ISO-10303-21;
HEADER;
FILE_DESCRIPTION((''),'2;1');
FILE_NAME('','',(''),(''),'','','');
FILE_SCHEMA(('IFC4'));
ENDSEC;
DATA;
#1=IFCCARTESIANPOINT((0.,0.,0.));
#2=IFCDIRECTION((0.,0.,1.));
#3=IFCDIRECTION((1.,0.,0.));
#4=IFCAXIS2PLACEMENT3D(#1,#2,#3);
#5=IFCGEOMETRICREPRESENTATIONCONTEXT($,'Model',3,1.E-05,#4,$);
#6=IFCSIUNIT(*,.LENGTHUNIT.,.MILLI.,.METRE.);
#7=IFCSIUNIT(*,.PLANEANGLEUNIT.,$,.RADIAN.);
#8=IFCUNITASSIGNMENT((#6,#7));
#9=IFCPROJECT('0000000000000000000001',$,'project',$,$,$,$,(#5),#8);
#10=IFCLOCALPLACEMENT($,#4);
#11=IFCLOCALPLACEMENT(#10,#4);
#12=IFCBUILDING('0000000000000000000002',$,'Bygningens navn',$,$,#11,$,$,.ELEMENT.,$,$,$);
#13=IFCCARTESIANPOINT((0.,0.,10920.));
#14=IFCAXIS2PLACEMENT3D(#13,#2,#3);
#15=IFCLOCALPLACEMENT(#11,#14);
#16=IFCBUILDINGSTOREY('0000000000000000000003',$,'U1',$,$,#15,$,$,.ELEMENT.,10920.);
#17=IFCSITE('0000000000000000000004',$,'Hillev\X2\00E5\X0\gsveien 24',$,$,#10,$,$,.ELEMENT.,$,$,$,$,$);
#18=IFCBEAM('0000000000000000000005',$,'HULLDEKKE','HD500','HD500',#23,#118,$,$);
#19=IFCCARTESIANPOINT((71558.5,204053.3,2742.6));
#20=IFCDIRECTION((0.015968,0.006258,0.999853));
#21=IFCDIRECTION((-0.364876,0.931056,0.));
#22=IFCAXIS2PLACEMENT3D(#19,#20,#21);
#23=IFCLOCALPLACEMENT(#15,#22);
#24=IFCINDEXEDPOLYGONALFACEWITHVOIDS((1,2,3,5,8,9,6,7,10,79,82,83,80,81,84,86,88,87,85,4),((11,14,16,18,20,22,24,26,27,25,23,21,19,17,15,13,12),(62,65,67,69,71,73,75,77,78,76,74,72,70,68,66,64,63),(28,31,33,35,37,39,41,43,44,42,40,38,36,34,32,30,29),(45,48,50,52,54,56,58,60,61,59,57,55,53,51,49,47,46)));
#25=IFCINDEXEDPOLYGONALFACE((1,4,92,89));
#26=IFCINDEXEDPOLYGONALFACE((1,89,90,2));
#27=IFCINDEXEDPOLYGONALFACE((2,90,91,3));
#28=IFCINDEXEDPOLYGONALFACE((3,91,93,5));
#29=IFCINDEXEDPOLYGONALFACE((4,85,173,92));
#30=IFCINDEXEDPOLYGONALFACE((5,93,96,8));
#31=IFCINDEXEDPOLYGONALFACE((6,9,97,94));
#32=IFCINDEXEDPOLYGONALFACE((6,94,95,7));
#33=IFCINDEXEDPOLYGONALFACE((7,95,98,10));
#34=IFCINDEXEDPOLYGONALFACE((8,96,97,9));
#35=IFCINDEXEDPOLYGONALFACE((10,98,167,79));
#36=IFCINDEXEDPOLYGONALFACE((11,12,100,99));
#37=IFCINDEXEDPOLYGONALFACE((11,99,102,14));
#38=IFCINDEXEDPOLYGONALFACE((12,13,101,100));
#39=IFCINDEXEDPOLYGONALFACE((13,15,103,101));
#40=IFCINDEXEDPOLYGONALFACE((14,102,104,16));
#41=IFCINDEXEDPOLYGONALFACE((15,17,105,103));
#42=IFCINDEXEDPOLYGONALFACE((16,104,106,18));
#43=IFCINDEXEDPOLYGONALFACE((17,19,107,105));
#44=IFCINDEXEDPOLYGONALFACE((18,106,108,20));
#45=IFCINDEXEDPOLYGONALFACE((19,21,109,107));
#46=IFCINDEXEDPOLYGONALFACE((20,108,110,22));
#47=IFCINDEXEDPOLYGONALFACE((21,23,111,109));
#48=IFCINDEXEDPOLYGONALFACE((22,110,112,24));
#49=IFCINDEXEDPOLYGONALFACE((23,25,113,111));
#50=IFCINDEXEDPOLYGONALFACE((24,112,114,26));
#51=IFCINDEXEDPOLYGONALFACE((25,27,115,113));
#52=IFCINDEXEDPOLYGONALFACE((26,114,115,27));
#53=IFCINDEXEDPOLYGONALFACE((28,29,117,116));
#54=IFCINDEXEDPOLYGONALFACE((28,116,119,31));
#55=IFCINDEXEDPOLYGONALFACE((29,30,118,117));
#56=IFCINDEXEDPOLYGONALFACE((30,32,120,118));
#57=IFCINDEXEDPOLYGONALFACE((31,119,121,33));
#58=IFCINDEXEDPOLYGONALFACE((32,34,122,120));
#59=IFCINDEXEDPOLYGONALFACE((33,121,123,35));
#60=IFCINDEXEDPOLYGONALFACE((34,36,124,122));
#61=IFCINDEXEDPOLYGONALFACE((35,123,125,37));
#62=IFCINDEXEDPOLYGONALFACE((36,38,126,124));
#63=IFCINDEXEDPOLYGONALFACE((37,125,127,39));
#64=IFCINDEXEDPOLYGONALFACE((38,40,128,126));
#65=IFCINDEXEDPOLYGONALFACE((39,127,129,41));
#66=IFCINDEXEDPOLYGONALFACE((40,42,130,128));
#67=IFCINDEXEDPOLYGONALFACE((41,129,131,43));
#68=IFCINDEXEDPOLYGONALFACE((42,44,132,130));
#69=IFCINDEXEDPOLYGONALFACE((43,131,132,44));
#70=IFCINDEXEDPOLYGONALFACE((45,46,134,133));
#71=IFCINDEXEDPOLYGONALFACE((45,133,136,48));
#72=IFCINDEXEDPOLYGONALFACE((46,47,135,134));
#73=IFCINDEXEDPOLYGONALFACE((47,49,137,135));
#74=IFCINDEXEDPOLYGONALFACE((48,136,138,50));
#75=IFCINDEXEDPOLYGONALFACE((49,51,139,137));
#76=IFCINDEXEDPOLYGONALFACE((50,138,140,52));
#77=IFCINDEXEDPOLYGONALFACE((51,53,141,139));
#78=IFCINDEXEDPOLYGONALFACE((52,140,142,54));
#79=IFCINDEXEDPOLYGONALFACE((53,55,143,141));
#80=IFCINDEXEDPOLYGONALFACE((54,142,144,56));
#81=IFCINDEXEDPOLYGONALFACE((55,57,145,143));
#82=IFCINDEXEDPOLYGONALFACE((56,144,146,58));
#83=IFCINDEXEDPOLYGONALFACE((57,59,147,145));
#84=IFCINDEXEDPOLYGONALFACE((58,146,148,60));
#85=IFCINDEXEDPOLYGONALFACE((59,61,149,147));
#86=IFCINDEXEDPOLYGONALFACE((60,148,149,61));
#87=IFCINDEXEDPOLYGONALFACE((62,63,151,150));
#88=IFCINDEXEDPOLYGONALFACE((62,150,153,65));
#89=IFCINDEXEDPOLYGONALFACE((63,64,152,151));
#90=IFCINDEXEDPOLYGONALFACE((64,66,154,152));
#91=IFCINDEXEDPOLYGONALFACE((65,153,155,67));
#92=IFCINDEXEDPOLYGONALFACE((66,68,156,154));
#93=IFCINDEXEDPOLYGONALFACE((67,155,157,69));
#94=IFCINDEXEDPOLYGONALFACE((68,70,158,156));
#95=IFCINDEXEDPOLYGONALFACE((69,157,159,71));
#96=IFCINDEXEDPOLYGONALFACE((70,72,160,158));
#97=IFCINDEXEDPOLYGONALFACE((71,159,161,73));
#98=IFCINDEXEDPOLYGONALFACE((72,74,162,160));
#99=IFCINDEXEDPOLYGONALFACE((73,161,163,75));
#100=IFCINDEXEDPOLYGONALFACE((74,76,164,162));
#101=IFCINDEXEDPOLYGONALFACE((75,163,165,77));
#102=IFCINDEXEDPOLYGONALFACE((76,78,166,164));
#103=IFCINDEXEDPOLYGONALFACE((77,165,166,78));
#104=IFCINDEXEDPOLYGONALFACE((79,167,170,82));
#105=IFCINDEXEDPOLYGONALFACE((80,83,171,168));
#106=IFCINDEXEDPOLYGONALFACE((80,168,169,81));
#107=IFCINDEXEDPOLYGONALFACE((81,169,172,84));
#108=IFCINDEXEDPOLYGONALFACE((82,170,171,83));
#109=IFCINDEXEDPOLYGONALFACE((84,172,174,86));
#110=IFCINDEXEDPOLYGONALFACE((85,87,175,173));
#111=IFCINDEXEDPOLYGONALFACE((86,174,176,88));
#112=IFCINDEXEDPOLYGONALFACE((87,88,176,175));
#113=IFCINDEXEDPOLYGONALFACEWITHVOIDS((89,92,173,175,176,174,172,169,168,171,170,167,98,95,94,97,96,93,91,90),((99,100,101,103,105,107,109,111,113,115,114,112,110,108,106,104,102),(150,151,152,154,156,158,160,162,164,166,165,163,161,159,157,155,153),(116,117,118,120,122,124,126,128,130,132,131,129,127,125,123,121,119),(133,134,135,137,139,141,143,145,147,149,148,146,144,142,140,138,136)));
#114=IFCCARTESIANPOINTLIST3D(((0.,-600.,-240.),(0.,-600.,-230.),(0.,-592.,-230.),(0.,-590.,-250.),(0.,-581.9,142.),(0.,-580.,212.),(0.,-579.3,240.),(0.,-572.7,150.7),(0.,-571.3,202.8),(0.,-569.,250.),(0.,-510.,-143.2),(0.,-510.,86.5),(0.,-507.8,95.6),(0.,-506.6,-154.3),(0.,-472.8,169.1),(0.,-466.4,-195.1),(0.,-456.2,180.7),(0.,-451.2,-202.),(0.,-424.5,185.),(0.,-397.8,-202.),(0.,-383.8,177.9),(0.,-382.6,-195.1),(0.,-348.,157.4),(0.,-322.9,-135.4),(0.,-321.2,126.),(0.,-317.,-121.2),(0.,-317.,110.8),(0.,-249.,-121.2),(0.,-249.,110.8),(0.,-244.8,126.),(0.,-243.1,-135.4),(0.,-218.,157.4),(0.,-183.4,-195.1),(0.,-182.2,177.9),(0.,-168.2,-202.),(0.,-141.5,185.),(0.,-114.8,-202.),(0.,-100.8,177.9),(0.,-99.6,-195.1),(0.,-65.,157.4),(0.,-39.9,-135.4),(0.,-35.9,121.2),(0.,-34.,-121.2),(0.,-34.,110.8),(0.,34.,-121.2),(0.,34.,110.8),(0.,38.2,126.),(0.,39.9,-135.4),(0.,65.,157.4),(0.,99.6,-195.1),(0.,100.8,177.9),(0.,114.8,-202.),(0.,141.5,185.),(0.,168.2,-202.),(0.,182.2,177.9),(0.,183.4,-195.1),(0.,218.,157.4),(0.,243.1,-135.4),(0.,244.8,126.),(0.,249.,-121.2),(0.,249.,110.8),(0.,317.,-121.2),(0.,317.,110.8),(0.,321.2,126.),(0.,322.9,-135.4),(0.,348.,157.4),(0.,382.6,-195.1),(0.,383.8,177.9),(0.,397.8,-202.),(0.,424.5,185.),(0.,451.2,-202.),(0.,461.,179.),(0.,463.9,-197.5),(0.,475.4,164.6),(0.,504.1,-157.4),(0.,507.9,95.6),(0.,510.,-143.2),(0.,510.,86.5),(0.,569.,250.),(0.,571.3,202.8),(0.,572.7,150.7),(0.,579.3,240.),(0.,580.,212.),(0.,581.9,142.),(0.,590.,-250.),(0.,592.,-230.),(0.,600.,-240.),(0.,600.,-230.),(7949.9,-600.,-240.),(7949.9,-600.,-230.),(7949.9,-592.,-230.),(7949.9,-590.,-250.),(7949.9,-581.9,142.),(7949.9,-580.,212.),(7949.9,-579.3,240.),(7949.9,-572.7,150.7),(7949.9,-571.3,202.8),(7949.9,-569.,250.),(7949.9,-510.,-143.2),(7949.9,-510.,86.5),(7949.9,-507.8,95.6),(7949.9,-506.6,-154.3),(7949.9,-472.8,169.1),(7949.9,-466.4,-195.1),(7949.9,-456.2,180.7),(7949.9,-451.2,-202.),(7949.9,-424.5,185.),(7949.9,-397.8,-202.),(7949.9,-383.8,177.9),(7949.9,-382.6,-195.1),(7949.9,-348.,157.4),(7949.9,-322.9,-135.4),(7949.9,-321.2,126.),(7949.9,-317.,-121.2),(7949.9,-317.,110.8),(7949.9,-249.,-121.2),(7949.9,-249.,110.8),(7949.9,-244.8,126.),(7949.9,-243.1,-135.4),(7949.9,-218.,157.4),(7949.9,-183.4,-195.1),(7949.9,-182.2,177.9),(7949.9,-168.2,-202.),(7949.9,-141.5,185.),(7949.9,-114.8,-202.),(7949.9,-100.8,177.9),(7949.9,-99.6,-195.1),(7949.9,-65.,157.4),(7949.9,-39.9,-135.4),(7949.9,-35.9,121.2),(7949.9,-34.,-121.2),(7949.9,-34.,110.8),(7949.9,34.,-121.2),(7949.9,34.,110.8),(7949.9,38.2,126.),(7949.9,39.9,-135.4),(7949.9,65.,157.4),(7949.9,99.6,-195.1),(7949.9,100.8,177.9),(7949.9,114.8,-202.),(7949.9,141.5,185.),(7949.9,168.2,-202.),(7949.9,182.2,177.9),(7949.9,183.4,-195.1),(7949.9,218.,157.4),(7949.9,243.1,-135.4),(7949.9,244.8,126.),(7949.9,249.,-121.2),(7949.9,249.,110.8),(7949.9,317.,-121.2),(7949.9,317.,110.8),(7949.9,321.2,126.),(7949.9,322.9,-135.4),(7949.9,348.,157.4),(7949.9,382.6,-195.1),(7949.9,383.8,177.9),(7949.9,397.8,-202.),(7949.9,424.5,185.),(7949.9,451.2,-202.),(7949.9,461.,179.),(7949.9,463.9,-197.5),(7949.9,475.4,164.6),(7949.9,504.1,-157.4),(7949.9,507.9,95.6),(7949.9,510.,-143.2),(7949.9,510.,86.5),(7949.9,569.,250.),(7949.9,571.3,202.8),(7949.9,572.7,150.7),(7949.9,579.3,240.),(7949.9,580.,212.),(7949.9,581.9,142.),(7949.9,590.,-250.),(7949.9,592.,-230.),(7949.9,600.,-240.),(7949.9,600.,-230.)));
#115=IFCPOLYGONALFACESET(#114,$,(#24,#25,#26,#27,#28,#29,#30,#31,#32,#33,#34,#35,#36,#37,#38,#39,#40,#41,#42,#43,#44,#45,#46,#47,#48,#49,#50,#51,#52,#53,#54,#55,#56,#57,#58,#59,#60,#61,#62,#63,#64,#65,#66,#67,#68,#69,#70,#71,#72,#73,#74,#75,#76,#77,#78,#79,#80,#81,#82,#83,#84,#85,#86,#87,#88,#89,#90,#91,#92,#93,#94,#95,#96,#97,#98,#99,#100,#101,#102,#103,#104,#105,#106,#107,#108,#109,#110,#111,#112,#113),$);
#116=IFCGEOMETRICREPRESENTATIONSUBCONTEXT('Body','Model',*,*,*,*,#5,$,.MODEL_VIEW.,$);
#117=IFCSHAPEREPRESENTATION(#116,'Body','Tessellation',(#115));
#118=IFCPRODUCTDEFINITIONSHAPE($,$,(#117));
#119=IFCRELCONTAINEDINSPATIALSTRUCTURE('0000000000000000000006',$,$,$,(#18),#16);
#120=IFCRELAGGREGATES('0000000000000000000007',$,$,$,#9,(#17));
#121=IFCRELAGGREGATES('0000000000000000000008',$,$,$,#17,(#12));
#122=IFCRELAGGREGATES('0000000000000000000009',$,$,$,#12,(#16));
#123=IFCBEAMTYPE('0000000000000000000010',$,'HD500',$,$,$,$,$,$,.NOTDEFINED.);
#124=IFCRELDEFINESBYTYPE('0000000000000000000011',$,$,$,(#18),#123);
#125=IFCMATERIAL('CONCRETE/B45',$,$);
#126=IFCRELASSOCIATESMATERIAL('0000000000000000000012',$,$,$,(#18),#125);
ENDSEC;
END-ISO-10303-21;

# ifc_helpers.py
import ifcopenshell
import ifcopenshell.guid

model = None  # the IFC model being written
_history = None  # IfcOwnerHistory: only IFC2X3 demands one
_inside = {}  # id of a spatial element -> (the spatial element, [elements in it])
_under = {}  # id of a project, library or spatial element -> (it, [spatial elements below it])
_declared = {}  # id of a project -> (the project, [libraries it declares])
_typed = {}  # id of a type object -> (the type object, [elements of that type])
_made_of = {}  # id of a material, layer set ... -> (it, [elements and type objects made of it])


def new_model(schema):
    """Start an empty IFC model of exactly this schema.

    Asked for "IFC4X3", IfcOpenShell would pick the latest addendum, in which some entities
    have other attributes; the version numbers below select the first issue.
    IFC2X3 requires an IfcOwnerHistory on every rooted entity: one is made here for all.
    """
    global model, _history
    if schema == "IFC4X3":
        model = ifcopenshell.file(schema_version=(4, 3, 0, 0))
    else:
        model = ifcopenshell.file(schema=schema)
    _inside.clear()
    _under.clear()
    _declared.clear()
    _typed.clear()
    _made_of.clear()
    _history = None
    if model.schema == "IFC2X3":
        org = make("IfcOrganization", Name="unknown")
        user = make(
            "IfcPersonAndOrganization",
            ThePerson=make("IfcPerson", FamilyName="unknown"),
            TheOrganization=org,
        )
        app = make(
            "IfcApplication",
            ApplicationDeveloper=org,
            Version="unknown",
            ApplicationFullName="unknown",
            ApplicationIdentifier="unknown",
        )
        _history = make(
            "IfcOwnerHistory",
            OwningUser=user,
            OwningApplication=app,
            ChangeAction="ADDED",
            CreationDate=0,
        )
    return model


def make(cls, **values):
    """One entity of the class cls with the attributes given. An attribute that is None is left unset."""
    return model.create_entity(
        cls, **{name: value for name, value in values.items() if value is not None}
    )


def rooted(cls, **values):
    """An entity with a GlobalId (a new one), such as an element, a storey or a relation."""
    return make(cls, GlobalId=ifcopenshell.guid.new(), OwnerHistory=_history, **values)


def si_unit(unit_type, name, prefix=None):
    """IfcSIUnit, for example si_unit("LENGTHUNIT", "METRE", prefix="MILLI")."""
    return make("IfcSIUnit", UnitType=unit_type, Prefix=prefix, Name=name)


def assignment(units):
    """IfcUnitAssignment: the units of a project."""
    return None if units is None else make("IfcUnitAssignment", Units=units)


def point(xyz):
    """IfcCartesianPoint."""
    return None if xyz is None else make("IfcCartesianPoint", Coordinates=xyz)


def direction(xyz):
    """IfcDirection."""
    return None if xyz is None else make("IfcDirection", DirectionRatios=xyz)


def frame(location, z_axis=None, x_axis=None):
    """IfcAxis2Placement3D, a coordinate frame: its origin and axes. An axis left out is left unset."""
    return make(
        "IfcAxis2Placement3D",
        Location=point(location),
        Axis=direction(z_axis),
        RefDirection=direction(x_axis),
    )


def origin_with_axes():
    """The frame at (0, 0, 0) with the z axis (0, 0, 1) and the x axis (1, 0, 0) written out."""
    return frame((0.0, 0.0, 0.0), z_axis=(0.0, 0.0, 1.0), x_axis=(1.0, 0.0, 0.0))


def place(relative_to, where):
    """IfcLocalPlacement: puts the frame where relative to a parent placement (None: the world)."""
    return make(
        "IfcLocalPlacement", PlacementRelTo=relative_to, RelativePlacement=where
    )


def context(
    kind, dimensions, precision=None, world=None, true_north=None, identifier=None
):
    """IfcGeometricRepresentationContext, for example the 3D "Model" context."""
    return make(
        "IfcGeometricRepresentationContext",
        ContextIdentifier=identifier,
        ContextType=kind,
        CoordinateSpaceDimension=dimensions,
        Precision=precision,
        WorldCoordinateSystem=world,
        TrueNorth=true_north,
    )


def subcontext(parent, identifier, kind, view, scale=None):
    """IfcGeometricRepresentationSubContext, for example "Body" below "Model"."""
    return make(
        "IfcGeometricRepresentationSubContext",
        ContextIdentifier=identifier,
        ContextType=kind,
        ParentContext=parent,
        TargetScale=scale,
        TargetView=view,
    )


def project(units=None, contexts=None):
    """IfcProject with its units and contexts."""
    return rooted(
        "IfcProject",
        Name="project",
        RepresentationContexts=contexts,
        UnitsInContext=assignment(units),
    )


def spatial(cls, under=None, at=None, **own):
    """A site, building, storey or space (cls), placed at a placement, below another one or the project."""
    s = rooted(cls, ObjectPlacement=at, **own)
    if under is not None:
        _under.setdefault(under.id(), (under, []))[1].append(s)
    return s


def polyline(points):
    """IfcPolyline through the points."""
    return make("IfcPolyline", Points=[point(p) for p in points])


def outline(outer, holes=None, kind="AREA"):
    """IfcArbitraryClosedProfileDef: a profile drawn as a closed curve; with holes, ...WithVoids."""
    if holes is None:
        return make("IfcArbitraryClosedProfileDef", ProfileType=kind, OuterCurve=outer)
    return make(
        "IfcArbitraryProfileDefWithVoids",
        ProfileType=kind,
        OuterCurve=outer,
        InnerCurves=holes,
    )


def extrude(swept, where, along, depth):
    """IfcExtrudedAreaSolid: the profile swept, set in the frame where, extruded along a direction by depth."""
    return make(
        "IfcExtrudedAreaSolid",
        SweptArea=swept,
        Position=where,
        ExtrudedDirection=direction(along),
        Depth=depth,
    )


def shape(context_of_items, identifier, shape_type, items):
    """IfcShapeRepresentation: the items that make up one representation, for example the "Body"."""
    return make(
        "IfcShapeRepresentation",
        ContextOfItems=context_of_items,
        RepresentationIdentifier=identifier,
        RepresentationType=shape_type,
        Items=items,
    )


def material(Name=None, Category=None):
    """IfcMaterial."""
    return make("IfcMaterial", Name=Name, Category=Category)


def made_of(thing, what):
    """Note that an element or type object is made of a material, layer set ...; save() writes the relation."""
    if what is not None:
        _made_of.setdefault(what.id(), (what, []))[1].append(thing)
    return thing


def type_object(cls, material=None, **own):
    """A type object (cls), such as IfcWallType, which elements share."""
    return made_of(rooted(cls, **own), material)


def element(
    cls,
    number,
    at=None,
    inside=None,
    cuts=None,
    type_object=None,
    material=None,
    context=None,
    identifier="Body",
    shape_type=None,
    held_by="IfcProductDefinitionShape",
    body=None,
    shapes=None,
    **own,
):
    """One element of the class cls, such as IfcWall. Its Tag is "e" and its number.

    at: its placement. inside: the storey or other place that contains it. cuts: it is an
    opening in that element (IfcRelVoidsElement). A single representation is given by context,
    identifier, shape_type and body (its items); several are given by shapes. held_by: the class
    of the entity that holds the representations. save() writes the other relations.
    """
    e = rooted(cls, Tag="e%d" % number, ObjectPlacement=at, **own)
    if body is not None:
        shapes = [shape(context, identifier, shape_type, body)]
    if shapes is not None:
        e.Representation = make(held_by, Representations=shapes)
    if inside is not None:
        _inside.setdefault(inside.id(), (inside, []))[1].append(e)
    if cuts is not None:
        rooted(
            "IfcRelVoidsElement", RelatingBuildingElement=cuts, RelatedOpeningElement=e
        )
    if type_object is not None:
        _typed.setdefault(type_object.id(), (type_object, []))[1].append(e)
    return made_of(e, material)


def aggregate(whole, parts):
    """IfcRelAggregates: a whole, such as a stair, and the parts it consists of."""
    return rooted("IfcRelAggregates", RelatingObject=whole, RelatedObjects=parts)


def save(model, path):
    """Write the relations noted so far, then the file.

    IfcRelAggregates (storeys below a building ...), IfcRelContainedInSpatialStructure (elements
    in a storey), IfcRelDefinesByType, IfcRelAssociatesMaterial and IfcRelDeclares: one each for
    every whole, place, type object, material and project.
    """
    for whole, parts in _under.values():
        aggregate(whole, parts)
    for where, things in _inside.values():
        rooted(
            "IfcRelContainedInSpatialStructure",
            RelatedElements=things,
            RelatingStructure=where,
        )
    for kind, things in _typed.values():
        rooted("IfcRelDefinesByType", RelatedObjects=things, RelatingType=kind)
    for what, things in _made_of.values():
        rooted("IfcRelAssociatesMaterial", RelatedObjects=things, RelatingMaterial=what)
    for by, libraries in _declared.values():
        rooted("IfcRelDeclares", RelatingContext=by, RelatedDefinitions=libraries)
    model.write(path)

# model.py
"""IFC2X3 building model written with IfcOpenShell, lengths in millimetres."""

from ifc_helpers import new_model, si_unit, frame, origin_with_axes, place, context, subcontext, project, spatial, polyline, outline, extrude, material, type_object, element, save


model = new_model("IFC2X3")

# Units and contexts
model_context = context("Model", 3, precision=1e-05, world=origin_with_axes())
body_context = subcontext(model_context, "Body", "Model", "MODEL_VIEW")
ifc_project = project(units=[si_unit("LENGTHUNIT", "METRE", prefix="MILLI"), si_unit("PLANEANGLEUNIT", "RADIAN")], contexts=[model_context])

# Site, building, storey
site_placement = place(None, origin_with_axes())
site = spatial("IfcSite", under=ifc_project, at=site_placement, Name="Hillevågsveien 24", CompositionType="ELEMENT")
building_placement = place(site_placement, origin_with_axes())
building = spatial("IfcBuilding", under=site, at=building_placement, Name="Bygningens navn", CompositionType="ELEMENT")
storey_placement = place(building_placement, frame((0.0, 0.0, 10920.0), z_axis=(0.0, 0.0, 1.0), x_axis=(1.0, 0.0, 0.0)))
storey = spatial("IfcBuildingStorey", under=building, at=storey_placement, Name="U1", CompositionType="ELEMENT", Elevation=10920.0)

# Beam
ifc_material_1 = material(Name="CONCRETE/B45")
beam_type_1 = type_object("IfcBeamType", Name="HD500", PredefinedType="NOTDEFINED")
beam_1_placement = place(storey_placement, frame((71558.5, 204053.3, 2742.6), z_axis=(0.015968, 0.006258, 0.999853), x_axis=(-0.364876, 0.931056, 0.0)))
element("IfcBeam", 1, at=beam_1_placement, inside=storey, type_object=beam_type_1, material=ifc_material_1, Name="HULLDEKKE", Description="HD500", ObjectType="HD500", context=body_context, shape_type="SweptSolid", body=[
    extrude(outline(polyline([(581.9, 142.0), (592.0, -230.0), (600.0, -230.0), (600.0, -240.0), (590.0, -250.0), (-590.0, -250.0), (-600.0, -240.0), (-600.0, -230.0), (-592.0, -230.0), (-581.9, 142.0), (-572.7, 150.7), (-571.3, 202.8), (-580.0, 212.0), (-579.3, 240.0), (-569.0, 250.0), (569.0, 250.0), (579.3, 240.0), (580.0, 212.0), (571.3, 202.8), (572.7, 150.7), (581.9, 142.0)]), holes=[polyline([(466.4, -195.1), (506.6, -154.3), (510.0, -143.2), (510.0, 86.5), (507.8, 95.6), (472.8, 169.1), (456.2, 180.7), (424.5, 185.0), (383.8, 177.9), (348.0, 157.4), (321.2, 126.0), (317.0, 110.8), (317.0, -121.2), (322.9, -135.4), (382.6, -195.1), (397.8, -202.0), (451.2, -202.0), (466.4, -195.1)]), polyline([(183.4, -195.1), (243.1, -135.4), (249.0, -121.2), (249.0, 110.8), (244.8, 126.0), (218.0, 157.4), (182.2, 177.9), (141.5, 185.0), (100.8, 177.9), (65.0, 157.4), (35.9, 121.2), (34.0, 110.8), (34.0, -121.2), (39.9, -135.4), (99.6, -195.1), (114.8, -202.0), (168.2, -202.0), (183.4, -195.1)]), polyline([(-99.6, -195.1), (-39.9, -135.4), (-34.0, -121.2), (-34.0, 110.8), (-38.2, 126.0), (-65.0, 157.4), (-100.8, 177.9), (-141.5, 185.0), (-182.2, 177.9), (-218.0, 157.4), (-244.8, 126.0), (-249.0, 110.8), (-249.0, -121.2), (-243.1, -135.4), (-183.4, -195.1), (-168.2, -202.0), (-114.8, -202.0), (-99.6, -195.1)]), polyline([(-382.6, -195.1), (-322.9, -135.4), (-317.0, -121.2), (-317.0, 110.8), (-321.2, 126.0), (-348.0, 157.4), (-383.8, 177.9), (-424.5, 185.0), (-461.0, 179.0), (-475.4, 164.6), (-507.9, 95.6), (-510.0, 86.5), (-510.0, -143.2), (-504.1, -157.4), (-463.9, -197.5), (-451.2, -202.0), (-397.8, -202.0), (-382.6, -195.1)])]), frame((7949.9, 0.0, 0.0), z_axis=(-1.0, 0.0, 0.0), x_axis=(0.0, -1.0, 0.0)), (0.0, 0.0, 1.0), 7949.9),
])

save(model, "model.ifc")
